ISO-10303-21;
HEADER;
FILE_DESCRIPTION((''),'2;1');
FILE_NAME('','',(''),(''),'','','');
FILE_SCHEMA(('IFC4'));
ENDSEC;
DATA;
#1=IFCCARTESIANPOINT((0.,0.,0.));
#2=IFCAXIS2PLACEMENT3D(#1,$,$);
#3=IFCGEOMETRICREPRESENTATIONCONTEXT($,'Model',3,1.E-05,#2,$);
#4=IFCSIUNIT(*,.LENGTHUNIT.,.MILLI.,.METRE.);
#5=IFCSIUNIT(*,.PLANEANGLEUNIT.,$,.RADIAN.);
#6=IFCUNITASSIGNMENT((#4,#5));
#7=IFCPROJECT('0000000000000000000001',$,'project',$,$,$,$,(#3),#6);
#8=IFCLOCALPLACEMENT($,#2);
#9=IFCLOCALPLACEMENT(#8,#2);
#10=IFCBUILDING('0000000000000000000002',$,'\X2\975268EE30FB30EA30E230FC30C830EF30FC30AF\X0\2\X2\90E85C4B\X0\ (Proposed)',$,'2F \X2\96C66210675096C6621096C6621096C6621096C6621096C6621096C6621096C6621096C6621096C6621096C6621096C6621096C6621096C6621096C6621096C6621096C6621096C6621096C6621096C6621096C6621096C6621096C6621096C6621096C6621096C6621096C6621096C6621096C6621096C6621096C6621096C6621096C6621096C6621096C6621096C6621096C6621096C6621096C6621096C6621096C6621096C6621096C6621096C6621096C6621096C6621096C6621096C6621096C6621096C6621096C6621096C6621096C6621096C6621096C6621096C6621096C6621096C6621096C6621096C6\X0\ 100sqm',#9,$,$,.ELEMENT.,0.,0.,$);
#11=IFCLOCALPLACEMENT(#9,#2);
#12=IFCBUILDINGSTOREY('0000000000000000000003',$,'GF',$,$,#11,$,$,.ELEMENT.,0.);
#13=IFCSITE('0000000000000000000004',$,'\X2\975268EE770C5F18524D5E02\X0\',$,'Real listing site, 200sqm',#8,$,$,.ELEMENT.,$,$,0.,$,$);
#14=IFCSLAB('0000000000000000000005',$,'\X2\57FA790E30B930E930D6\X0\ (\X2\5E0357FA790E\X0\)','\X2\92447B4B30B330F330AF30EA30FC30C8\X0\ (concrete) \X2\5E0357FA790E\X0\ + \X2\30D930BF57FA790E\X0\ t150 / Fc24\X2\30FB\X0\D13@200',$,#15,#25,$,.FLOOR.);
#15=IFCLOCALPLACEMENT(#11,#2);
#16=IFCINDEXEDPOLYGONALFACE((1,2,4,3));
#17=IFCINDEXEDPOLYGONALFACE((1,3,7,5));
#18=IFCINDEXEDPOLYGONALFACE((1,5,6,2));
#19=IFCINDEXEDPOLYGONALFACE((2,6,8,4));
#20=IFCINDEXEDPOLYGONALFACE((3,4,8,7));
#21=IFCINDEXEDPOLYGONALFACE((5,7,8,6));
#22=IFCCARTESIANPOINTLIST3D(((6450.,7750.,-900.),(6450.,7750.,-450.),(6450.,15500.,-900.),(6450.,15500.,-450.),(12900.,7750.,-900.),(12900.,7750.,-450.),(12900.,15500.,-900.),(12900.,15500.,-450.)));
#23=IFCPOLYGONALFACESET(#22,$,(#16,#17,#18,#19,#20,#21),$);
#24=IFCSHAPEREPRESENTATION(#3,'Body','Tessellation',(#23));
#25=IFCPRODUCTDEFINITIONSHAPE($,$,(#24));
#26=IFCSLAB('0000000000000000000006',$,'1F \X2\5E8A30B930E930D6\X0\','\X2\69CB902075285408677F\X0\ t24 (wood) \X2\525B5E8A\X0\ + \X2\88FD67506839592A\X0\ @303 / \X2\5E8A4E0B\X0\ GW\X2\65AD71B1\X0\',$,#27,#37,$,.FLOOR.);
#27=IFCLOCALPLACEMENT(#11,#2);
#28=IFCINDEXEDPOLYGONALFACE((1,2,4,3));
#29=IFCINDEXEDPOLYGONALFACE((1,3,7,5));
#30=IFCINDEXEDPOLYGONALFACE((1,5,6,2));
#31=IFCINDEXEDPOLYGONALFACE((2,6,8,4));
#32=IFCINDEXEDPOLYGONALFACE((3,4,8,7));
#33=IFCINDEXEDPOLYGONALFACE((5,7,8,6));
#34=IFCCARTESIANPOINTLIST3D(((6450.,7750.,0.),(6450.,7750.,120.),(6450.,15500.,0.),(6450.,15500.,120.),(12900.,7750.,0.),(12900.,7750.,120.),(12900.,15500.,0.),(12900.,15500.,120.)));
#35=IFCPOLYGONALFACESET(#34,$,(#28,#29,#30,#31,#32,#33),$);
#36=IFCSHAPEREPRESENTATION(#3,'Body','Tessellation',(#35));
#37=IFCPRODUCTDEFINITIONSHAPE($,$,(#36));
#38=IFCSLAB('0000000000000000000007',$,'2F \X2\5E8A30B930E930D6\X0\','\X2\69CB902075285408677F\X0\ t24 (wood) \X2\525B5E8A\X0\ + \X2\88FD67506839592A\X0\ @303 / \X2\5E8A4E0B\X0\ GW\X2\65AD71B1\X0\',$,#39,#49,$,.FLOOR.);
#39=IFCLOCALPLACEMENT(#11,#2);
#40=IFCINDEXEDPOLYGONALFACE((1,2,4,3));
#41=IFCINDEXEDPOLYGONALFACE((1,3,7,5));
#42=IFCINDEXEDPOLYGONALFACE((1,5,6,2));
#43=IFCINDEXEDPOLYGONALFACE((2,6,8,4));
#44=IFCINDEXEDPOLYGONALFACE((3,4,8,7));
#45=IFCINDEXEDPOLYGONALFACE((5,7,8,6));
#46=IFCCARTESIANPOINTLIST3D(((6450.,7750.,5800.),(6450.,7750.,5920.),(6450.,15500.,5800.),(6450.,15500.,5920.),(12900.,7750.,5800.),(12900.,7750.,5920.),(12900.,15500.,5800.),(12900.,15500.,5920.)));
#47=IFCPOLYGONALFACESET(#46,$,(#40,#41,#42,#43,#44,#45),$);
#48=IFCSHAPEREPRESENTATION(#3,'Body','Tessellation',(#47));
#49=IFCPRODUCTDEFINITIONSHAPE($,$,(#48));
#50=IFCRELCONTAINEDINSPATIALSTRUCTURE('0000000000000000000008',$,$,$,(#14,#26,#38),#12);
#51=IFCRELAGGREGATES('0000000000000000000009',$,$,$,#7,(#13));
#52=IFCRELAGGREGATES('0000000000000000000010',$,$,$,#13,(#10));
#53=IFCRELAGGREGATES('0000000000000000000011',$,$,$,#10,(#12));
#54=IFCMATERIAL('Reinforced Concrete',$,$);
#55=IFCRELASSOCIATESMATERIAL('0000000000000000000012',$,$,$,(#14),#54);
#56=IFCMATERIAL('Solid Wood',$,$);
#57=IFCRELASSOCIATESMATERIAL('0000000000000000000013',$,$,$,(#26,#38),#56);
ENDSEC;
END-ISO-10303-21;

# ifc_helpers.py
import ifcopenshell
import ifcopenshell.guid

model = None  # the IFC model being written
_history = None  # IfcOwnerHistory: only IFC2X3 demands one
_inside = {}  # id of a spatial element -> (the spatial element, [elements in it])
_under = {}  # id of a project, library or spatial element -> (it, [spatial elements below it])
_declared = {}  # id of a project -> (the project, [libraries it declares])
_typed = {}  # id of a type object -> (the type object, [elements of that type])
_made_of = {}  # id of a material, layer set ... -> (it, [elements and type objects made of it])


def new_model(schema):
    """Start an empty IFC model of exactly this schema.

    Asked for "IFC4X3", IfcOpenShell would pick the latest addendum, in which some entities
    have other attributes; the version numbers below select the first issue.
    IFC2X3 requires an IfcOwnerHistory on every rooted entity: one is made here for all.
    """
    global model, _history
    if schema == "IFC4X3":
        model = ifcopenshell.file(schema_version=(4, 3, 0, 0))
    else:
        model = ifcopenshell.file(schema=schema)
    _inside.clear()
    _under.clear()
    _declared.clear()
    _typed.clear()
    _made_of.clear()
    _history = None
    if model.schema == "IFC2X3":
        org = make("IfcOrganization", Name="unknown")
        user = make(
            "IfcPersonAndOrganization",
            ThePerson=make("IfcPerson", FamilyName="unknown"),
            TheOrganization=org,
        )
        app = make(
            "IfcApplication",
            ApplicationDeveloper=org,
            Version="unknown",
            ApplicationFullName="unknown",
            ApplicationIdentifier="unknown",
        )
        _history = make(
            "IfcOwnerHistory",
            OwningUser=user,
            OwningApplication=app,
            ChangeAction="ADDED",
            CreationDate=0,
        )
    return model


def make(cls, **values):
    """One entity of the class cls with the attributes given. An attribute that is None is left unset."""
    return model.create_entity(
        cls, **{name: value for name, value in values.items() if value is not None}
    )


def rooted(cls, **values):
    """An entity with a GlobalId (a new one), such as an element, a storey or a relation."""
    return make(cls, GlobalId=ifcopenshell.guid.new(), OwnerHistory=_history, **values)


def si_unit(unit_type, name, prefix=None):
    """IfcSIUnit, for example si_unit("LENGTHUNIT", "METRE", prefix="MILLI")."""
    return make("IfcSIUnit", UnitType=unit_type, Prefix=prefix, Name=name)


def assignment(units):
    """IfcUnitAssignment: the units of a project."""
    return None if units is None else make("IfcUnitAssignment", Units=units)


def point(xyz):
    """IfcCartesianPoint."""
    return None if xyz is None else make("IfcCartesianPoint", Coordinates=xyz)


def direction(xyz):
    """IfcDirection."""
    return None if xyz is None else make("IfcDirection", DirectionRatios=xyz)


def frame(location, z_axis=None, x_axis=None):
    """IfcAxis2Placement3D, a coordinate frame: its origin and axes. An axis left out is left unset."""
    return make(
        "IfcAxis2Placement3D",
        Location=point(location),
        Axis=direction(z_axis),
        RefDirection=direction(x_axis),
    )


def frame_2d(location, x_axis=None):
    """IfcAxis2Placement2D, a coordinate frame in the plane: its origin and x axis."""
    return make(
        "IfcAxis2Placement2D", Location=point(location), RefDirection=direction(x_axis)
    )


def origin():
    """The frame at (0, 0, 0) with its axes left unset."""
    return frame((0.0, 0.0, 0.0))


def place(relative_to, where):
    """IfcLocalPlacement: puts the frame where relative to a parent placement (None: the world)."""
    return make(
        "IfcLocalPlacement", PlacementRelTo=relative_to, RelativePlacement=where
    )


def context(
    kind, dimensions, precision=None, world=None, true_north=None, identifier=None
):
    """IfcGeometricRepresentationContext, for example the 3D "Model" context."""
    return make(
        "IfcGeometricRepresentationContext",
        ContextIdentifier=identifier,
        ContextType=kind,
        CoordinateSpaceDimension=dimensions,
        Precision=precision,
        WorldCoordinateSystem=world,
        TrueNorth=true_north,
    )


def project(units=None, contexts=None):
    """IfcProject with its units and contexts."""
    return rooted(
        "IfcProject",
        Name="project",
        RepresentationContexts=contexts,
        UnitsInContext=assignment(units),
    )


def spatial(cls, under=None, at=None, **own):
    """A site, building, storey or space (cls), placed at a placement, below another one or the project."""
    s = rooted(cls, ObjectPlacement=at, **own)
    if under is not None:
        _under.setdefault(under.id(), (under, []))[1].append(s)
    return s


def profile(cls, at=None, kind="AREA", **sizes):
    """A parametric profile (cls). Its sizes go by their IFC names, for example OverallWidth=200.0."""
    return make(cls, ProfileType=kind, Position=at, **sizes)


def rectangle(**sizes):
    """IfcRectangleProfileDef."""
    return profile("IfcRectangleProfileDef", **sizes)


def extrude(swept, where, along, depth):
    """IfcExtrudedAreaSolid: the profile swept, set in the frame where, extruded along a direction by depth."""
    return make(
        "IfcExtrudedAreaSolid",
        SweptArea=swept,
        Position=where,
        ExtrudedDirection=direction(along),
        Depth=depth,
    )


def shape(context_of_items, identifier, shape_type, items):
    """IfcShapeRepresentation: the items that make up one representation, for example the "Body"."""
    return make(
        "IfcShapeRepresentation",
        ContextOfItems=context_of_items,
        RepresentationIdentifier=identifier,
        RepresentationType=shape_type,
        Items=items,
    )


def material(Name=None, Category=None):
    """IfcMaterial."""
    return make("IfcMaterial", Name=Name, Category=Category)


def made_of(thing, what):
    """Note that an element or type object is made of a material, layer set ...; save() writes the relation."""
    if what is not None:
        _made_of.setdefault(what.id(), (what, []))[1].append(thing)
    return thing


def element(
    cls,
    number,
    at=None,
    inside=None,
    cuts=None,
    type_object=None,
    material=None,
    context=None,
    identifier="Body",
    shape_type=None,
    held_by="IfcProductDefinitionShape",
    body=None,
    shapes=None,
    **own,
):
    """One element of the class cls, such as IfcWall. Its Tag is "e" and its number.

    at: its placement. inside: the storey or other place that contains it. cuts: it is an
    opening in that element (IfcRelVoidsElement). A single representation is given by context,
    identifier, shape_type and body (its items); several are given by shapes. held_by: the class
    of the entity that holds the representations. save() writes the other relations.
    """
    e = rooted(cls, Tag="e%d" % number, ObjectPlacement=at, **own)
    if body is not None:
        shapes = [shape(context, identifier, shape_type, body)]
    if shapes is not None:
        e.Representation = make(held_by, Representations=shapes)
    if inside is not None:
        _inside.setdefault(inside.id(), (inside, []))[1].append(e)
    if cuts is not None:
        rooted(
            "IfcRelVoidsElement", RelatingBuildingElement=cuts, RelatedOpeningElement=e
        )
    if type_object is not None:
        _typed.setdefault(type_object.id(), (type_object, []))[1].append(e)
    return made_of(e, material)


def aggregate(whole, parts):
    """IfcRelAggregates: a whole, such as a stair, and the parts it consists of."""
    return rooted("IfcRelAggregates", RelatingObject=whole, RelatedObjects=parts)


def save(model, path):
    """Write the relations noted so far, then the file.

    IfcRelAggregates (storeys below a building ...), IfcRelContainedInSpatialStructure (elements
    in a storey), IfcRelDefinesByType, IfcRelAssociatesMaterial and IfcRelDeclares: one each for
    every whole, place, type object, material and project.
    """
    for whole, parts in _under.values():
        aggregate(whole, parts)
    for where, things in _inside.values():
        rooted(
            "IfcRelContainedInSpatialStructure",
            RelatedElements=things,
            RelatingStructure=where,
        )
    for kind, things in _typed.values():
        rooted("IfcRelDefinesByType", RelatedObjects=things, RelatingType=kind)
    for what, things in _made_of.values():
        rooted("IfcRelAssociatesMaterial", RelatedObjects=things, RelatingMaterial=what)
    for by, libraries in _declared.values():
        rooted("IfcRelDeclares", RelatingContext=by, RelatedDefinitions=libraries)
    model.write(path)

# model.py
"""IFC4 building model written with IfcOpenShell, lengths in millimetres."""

from ifc_helpers import new_model, si_unit, frame, frame_2d, origin, place, context, project, spatial, rectangle, extrude, material, element, save


model = new_model("IFC4")

# Units and contexts
model_context = context("Model", 3, precision=1e-05, world=origin())
ifc_project = project(units=[si_unit("LENGTHUNIT", "METRE", prefix="MILLI"), si_unit("PLANEANGLEUNIT", "RADIAN")], contexts=[model_context])

# Site, building, storey
site_placement = place(None, origin())
site = spatial("IfcSite", under=ifc_project, at=site_placement, Name="青森県弘前市", ObjectType="Real listing site, 200sqm", CompositionType="ELEMENT", RefElevation=0.0)
building_placement = place(site_placement, origin())
building = spatial("IfcBuilding", under=site, at=building_placement, Name="青森・リモートワーク2部屋 (Proposed)", ObjectType="2F 集成材集成集成集成集成集成集成集成集成集成集成集成集成集成集成集成集成集成集成集成集成集成集成集成集成集成集成集成集成集成集成集成集成集成集成集成集成集成集成集成集成集成集成集成集成集成集成集成集成集成集成集成集成集成集成集成集成集成集成集 100sqm", CompositionType="ELEMENT", ElevationOfRefHeight=0.0, ElevationOfTerrain=0.0)
storey_placement = place(building_placement, origin())
storey = spatial("IfcBuildingStorey", under=building, at=storey_placement, Name="GF", CompositionType="ELEMENT", Elevation=0.0)

# Shared definitions
ifc_material_1 = material(Name="Solid Wood")

# Slabs
ifc_material_2 = material(Name="Reinforced Concrete")
slab_1_placement = place(storey_placement, frame((3225.0, 3875.0, -450.0)))
element("IfcSlab", 1, at=slab_1_placement, inside=storey, material=ifc_material_2, Name="基礎スラブ (布基礎)", Description="鉄筋コンクリート (concrete) 布基礎 + ベタ基礎 t150 / Fc24・D13@200", PredefinedType="FLOOR", context=model_context, shape_type="SweptSolid", body=[
    extrude(rectangle(XDim=6450.0, YDim=7750.0, at=frame_2d((3225.0, 3875.0))), frame((3225.0, 3875.0, -450.0)), (0.0, 0.0, 1.0), 450.0),
])
slab_2_placement = place(storey_placement, frame((3225.0, 3875.0, 0.0)))
element("IfcSlab", 2, at=slab_2_placement, inside=storey, material=ifc_material_1, Name="1F 床スラブ", Description="構造用合板 t24 (wood) 剛床 + 製材根太 @303 / 床下 GW断熱", PredefinedType="FLOOR", context=model_context, shape_type="SweptSolid", body=[
    extrude(rectangle(XDim=6450.0, YDim=7750.0, at=frame_2d((3225.0, 3875.0))), frame((3225.0, 3875.0, 0.0)), (0.0, 0.0, 1.0), 120.0),
])
slab_3_placement = place(storey_placement, frame((3225.0, 3875.0, 2900.0)))
element("IfcSlab", 3, at=slab_3_placement, inside=storey, material=ifc_material_1, Name="2F 床スラブ", Description="構造用合板 t24 (wood) 剛床 + 製材根太 @303 / 床下 GW断熱", PredefinedType="FLOOR", context=model_context, shape_type="SweptSolid", body=[
    extrude(rectangle(XDim=6450.0, YDim=7750.0, at=frame_2d((3225.0, 3875.0))), frame((3225.0, 3875.0, 2900.0)), (0.0, 0.0, 1.0), 120.0),
])

save(model, "model.ifc")
